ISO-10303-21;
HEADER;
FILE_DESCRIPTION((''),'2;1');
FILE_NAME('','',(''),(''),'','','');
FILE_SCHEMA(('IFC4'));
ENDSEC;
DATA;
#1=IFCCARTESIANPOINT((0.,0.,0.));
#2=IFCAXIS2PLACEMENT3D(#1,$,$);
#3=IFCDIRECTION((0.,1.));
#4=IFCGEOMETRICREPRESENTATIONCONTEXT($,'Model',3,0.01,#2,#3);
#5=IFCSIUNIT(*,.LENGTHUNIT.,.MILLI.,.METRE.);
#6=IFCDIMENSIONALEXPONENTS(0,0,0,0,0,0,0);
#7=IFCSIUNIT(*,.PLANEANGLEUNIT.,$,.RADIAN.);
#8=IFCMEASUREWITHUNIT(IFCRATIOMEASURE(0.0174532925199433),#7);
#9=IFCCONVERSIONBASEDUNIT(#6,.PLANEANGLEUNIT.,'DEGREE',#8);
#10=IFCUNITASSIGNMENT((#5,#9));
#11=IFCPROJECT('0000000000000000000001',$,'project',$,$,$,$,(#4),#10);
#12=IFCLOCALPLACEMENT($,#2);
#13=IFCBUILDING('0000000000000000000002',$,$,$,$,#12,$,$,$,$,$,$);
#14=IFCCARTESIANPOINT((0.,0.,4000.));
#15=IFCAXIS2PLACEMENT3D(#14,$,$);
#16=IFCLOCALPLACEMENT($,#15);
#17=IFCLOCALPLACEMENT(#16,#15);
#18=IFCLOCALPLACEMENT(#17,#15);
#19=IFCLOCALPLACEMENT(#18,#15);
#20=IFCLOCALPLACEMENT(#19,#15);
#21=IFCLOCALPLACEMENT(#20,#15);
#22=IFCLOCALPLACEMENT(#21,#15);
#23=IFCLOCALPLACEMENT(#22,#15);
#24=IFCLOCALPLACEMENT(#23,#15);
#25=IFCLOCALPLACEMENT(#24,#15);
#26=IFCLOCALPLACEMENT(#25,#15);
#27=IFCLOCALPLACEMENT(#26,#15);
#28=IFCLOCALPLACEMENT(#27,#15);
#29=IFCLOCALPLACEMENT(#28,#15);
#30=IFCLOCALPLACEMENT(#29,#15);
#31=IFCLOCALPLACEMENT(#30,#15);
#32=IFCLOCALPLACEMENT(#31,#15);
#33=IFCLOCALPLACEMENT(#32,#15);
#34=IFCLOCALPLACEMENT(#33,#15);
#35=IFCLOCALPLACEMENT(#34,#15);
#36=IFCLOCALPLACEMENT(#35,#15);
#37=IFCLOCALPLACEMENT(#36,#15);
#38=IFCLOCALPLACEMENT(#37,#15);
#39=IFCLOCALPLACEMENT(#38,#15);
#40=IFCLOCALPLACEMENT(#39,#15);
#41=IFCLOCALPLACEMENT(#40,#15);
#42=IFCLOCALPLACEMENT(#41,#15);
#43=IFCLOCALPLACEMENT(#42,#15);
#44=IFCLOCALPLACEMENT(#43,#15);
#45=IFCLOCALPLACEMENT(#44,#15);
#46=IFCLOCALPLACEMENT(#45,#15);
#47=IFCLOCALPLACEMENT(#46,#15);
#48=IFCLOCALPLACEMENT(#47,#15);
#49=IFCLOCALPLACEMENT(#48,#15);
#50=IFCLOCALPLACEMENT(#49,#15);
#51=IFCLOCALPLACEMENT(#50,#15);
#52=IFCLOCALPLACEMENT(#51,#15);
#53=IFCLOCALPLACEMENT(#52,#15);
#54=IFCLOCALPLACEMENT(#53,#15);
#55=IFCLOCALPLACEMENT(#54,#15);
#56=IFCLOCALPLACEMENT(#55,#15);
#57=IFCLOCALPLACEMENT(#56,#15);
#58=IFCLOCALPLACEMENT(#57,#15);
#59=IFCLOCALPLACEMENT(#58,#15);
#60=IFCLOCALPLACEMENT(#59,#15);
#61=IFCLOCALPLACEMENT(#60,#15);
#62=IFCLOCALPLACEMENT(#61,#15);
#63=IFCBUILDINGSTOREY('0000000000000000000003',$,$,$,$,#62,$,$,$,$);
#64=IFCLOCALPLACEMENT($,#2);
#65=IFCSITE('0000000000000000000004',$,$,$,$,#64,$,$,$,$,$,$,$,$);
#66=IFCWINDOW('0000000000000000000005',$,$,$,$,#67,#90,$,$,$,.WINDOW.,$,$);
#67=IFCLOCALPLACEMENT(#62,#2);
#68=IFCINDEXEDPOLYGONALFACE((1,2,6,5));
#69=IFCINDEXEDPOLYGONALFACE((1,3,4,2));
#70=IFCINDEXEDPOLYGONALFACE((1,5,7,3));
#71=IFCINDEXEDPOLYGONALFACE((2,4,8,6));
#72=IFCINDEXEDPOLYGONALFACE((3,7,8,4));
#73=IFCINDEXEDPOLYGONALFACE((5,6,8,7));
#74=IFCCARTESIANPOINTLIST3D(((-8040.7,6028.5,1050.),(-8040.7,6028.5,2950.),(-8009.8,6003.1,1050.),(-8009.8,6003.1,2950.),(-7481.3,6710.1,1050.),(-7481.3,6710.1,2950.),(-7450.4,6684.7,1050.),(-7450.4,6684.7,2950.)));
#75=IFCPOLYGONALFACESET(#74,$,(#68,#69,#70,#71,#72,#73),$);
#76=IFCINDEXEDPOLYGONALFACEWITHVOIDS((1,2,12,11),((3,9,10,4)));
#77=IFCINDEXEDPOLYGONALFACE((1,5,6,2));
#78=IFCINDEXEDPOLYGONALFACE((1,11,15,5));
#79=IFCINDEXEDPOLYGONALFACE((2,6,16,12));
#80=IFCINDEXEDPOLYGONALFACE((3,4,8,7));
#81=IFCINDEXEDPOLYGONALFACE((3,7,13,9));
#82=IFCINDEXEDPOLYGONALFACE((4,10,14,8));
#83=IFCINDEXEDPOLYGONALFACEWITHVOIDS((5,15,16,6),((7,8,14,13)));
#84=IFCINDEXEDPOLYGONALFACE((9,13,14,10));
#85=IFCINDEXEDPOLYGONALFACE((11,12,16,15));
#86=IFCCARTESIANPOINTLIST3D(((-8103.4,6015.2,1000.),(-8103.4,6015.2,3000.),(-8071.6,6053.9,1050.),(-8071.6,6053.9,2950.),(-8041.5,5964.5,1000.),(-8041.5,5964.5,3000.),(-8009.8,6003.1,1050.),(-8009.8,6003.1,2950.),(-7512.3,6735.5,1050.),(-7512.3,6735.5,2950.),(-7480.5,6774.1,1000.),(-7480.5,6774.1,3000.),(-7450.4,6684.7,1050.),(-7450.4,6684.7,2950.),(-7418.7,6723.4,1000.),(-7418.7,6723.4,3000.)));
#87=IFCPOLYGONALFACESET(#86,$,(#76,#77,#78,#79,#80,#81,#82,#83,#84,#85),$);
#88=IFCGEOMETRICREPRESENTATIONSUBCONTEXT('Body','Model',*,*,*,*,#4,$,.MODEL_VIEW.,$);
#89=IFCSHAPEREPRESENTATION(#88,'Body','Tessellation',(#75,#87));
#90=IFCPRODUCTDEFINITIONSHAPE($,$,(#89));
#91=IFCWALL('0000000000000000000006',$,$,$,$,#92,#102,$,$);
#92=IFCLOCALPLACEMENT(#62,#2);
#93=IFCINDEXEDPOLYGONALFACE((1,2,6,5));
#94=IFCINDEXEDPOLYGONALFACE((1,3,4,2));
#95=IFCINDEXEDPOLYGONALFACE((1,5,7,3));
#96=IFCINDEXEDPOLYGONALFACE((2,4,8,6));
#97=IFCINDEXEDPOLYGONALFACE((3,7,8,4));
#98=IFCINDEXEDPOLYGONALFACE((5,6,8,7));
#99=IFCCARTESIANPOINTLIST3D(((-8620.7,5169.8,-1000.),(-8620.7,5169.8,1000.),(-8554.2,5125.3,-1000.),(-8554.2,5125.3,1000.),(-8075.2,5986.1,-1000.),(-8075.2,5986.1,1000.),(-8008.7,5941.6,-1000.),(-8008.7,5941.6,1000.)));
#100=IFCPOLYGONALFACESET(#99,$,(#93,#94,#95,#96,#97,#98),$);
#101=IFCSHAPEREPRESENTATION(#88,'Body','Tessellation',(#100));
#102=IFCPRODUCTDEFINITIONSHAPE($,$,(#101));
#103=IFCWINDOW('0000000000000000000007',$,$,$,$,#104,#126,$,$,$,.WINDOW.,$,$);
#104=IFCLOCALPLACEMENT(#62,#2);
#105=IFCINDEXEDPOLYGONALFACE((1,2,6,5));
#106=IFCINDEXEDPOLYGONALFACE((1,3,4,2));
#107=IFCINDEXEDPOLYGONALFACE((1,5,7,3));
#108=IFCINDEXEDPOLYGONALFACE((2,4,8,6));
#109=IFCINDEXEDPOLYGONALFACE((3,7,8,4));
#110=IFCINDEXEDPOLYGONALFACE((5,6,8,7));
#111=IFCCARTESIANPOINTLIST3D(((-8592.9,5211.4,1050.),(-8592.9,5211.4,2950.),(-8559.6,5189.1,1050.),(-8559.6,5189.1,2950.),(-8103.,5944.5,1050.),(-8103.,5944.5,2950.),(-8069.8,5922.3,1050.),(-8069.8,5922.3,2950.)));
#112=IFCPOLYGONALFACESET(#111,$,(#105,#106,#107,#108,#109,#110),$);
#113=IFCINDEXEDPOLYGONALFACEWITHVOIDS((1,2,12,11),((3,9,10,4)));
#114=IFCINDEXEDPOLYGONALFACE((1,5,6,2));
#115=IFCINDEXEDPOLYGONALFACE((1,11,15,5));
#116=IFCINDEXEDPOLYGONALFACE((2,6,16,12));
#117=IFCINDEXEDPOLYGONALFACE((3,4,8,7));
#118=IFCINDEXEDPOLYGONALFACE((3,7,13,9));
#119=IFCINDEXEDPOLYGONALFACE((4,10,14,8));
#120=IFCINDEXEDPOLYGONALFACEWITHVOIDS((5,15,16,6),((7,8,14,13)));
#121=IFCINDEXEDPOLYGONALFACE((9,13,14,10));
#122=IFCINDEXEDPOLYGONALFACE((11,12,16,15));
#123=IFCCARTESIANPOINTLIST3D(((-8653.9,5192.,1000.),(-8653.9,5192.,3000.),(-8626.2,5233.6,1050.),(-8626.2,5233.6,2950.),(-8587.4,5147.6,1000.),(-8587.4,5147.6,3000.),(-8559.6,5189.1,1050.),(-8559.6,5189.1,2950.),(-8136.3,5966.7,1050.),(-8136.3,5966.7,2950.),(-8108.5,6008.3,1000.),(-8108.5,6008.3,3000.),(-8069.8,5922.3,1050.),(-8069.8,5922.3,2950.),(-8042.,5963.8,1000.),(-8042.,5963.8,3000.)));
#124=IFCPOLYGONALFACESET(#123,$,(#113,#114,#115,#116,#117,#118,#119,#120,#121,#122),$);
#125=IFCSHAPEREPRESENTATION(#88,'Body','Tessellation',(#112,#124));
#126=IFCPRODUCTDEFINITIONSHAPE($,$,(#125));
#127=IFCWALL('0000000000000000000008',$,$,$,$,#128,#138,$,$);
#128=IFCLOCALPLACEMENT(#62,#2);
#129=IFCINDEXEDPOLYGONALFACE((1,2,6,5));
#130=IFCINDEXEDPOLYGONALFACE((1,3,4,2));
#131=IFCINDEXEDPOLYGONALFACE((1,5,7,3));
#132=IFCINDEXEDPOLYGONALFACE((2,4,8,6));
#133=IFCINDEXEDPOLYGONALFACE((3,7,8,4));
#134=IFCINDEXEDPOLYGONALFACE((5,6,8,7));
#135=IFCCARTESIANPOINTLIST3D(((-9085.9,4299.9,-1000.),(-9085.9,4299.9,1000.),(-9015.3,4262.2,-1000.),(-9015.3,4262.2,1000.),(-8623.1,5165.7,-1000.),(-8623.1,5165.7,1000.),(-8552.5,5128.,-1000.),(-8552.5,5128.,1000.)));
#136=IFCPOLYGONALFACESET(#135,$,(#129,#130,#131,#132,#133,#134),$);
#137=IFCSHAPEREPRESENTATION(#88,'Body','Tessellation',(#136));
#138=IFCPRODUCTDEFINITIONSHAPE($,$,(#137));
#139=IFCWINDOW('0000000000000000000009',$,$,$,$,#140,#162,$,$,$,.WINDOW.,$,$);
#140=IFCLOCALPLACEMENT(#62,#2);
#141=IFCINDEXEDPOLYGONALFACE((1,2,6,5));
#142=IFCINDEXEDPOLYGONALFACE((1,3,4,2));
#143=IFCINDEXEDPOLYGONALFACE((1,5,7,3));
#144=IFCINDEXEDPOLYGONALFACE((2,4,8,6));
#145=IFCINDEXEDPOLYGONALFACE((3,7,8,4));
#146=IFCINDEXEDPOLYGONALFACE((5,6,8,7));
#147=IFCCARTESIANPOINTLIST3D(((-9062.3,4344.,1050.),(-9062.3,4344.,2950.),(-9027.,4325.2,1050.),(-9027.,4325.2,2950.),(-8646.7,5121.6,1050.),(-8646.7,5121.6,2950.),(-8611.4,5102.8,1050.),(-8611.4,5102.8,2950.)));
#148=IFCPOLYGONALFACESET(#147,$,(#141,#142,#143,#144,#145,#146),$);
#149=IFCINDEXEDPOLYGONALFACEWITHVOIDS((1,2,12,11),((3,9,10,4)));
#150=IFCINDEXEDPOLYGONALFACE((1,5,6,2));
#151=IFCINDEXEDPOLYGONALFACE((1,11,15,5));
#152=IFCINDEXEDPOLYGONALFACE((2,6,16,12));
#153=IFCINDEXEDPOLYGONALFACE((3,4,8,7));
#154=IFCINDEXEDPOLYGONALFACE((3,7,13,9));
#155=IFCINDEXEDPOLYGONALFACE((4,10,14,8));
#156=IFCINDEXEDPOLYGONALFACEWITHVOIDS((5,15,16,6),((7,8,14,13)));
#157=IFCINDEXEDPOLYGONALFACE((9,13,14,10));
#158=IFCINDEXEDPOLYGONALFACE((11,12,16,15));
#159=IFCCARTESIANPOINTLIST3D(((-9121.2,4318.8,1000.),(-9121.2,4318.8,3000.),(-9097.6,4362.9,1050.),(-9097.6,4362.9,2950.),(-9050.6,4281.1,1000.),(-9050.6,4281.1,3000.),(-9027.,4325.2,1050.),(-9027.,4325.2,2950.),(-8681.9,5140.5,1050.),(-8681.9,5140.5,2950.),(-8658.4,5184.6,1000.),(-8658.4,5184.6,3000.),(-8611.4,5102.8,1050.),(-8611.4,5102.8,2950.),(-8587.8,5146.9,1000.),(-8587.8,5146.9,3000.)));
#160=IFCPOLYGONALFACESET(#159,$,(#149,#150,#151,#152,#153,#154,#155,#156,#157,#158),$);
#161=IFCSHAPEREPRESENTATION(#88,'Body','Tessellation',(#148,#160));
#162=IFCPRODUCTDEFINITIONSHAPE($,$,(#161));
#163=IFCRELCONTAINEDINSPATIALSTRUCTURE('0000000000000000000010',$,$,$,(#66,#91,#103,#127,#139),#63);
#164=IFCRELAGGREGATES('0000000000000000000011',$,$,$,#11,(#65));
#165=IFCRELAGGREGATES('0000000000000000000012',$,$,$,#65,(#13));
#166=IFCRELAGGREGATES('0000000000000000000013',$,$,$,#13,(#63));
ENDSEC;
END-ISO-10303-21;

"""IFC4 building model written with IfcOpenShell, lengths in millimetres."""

from ifc_helpers import new_model, entity, si_unit, converted_unit, direction, frame, origin, origin_2d, place, context, subcontext, project, spatial, rectangle, extrude, element, save


model = new_model("IFC4")

# Units and contexts
model_context = context("Model", 3, precision=0.01, world=origin(), true_north=direction((0.0, 1.0)))
body_context = subcontext(model_context, "Body", "Model", "MODEL_VIEW")
ifc_project = project(units=[si_unit("LENGTHUNIT", "METRE", prefix="MILLI"), converted_unit("PLANEANGLEUNIT", "DEGREE", entity("IfcRatioMeasure", 0.0174532925199433), si_unit("PLANEANGLEUNIT", "RADIAN"), dimensions=[0, 0, 0, 0, 0, 0, 0])], contexts=[model_context])

# Site, building, storey
site_placement = place(None, origin())
site = spatial("IfcSite", under=ifc_project, at=site_placement)
building_placement = place(None, origin())
building = spatial("IfcBuilding", under=site, at=building_placement)
placement_1 = place(None, frame((0.0, 0.0, 4000.0)))
placement_2 = place(placement_1, frame((0.0, 0.0, 4000.0)))
placement_3 = place(placement_2, frame((0.0, 0.0, 4000.0)))
placement_4 = place(placement_3, frame((0.0, 0.0, 4000.0)))
placement_5 = place(placement_4, frame((0.0, 0.0, 4000.0)))
placement_6 = place(placement_5, frame((0.0, 0.0, 4000.0)))
placement_7 = place(placement_6, frame((0.0, 0.0, 4000.0)))
placement_8 = place(placement_7, frame((0.0, 0.0, 4000.0)))
placement_9 = place(placement_8, frame((0.0, 0.0, 4000.0)))
placement_10 = place(placement_9, frame((0.0, 0.0, 4000.0)))
placement_11 = place(placement_10, frame((0.0, 0.0, 4000.0)))
placement_12 = place(placement_11, frame((0.0, 0.0, 4000.0)))
placement_13 = place(placement_12, frame((0.0, 0.0, 4000.0)))
placement_14 = place(placement_13, frame((0.0, 0.0, 4000.0)))
placement_15 = place(placement_14, frame((0.0, 0.0, 4000.0)))
placement_16 = place(placement_15, frame((0.0, 0.0, 4000.0)))
placement_17 = place(placement_16, frame((0.0, 0.0, 4000.0)))
placement_18 = place(placement_17, frame((0.0, 0.0, 4000.0)))
placement_19 = place(placement_18, frame((0.0, 0.0, 4000.0)))
placement_20 = place(placement_19, frame((0.0, 0.0, 4000.0)))
placement_21 = place(placement_20, frame((0.0, 0.0, 4000.0)))
placement_22 = place(placement_21, frame((0.0, 0.0, 4000.0)))
placement_23 = place(placement_22, frame((0.0, 0.0, 4000.0)))
placement_24 = place(placement_23, frame((0.0, 0.0, 4000.0)))
placement_25 = place(placement_24, frame((0.0, 0.0, 4000.0)))
placement_26 = place(placement_25, frame((0.0, 0.0, 4000.0)))
placement_27 = place(placement_26, frame((0.0, 0.0, 4000.0)))
placement_28 = place(placement_27, frame((0.0, 0.0, 4000.0)))
placement_29 = place(placement_28, frame((0.0, 0.0, 4000.0)))
placement_30 = place(placement_29, frame((0.0, 0.0, 4000.0)))
placement_31 = place(placement_30, frame((0.0, 0.0, 4000.0)))
placement_32 = place(placement_31, frame((0.0, 0.0, 4000.0)))
placement_33 = place(placement_32, frame((0.0, 0.0, 4000.0)))
placement_34 = place(placement_33, frame((0.0, 0.0, 4000.0)))
placement_35 = place(placement_34, frame((0.0, 0.0, 4000.0)))
placement_36 = place(placement_35, frame((0.0, 0.0, 4000.0)))
placement_37 = place(placement_36, frame((0.0, 0.0, 4000.0)))
placement_38 = place(placement_37, frame((0.0, 0.0, 4000.0)))
placement_39 = place(placement_38, frame((0.0, 0.0, 4000.0)))
placement_40 = place(placement_39, frame((0.0, 0.0, 4000.0)))
placement_41 = place(placement_40, frame((0.0, 0.0, 4000.0)))
placement_42 = place(placement_41, frame((0.0, 0.0, 4000.0)))
placement_43 = place(placement_42, frame((0.0, 0.0, 4000.0)))
placement_44 = place(placement_43, frame((0.0, 0.0, 4000.0)))
placement_45 = place(placement_44, frame((0.0, 0.0, 4000.0)))
placement_46 = place(placement_45, frame((0.0, 0.0, 4000.0)))
storey_placement = place(placement_46, frame((0.0, 0.0, 4000.0)))
storey = spatial("IfcBuildingStorey", under=building, at=storey_placement)

# Shared definitions
cartesian_point_1 = entity("IfcCartesianPoint", [-440.9, -950.0])
shared_polyline = entity("IfcPolyline", [cartesian_point_1, entity("IfcCartesianPoint", [-440.9, 950.0]), entity("IfcCartesianPoint", [-440.9, 950.0]), entity("IfcCartesianPoint", [440.9, 950.0]), entity("IfcCartesianPoint", [440.9, 950.0]), entity("IfcCartesianPoint", [440.9, -950.0]), entity("IfcCartesianPoint", [440.9, -950.0]), entity("IfcCartesianPoint", [-440.9, -950.0]), cartesian_point_1])

# Window
window_1_placement = place(storey_placement, frame((-7730.1, 6343.9, 2000.0), z_axis=(0.0, 0.0, 1.0), x_axis=(-6343.932486, -7730.104825, 0.0)))
cartesian_point_2 = entity("IfcCartesianPoint", [-490.9, -1000.0])
element("IfcWindow", 1, at=window_1_placement, inside=storey, PredefinedType="WINDOW", context=body_context, shape_type="SweptSolid", body=[
    entity("IfcExtrudedAreaSolid", entity("IfcArbitraryClosedProfileDef", "AREA", None, shared_polyline), entity("IfcAxis2Placement3D", entity("IfcCartesianPoint", [0.0, 0.0, 0.0]), entity("IfcDirection", [0.0, -1.0, 0.0]), entity("IfcDirection", [1.0, 0.0, 0.0])), entity("IfcDirection", [0.0, 0.0, 1.0]), 40.0),
    entity("IfcExtrudedAreaSolid", entity("IfcArbitraryProfileDefWithVoids", "AREA", None, entity("IfcPolyline", [cartesian_point_2, entity("IfcCartesianPoint", [-490.9, 1000.0]), entity("IfcCartesianPoint", [-490.9, 1000.0]), entity("IfcCartesianPoint", [490.9, 1000.0]), entity("IfcCartesianPoint", [490.9, 1000.0]), entity("IfcCartesianPoint", [490.9, -1000.0]), entity("IfcCartesianPoint", [490.9, -1000.0]), entity("IfcCartesianPoint", [-490.9, -1000.0]), cartesian_point_2]), [shared_polyline]), entity("IfcAxis2Placement3D", entity("IfcCartesianPoint", [0.0, 0.0, 0.0]), entity("IfcDirection", [0.0, -1.0, 0.0]), entity("IfcDirection", [1.0, 0.0, 0.0])), entity("IfcDirection", [0.0, 0.0, 1.0]), 80.0),
])

# Wall
wall_1_placement = place(storey_placement, frame((-8314.7, 5555.7, -1000.0), z_axis=(0.0, 0.0, 1.0), x_axis=(-5555.701616, -8314.6966, 0.0)))
element("IfcWall", 2, at=wall_1_placement, inside=storey, context=body_context, shape_type="SweptSolid", body=[
    extrude(rectangle(XDim=981.7, YDim=80.0, at=origin_2d()), origin(), (0.0, 0.0, 1.0), 2000.0),
])

# Window
window_2_placement = place(storey_placement, frame((-8314.7, 5555.7, 2000.0), z_axis=(0.0, 0.0, 1.0), x_axis=(-5555.701616, -8314.6966, 0.0)))
cartesian_point_3 = entity("IfcCartesianPoint", [-490.9, -1000.0])
element("IfcWindow", 3, at=window_2_placement, inside=storey, PredefinedType="WINDOW", context=body_context, shape_type="SweptSolid", body=[
    entity("IfcExtrudedAreaSolid", entity("IfcArbitraryClosedProfileDef", "AREA", None, shared_polyline), entity("IfcAxis2Placement3D", entity("IfcCartesianPoint", [0.0, 0.0, 0.0]), entity("IfcDirection", [0.0, -1.0, 0.0]), entity("IfcDirection", [1.0, 0.0, 0.0])), entity("IfcDirection", [0.0, 0.0, 1.0]), 40.0),
    entity("IfcExtrudedAreaSolid", entity("IfcArbitraryProfileDefWithVoids", "AREA", None, entity("IfcPolyline", [cartesian_point_3, entity("IfcCartesianPoint", [-490.9, 1000.0]), entity("IfcCartesianPoint", [-490.9, 1000.0]), entity("IfcCartesianPoint", [490.9, 1000.0]), entity("IfcCartesianPoint", [490.9, 1000.0]), entity("IfcCartesianPoint", [490.9, -1000.0]), entity("IfcCartesianPoint", [490.9, -1000.0]), entity("IfcCartesianPoint", [-490.9, -1000.0]), cartesian_point_3]), [shared_polyline]), entity("IfcAxis2Placement3D", entity("IfcCartesianPoint", [0.0, 0.0, 0.0]), entity("IfcDirection", [0.0, -1.0, 0.0]), entity("IfcDirection", [1.0, 0.0, 0.0])), entity("IfcDirection", [0.0, 0.0, 1.0]), 80.0),
])

# Wall
wall_2_placement = place(storey_placement, frame((-8819.2, 4714.0, -1000.0), z_axis=(0.0, 0.0, 1.0), x_axis=(-4713.96836, -8819.212113, 0.0)))
element("IfcWall", 4, at=wall_2_placement, inside=storey, context=body_context, shape_type="SweptSolid", body=[
    extrude(rectangle(XDim=981.7, YDim=80.0, at=origin_2d()), origin(), (0.0, 0.0, 1.0), 2000.0),
])

# Window
window_3_placement = place(storey_placement, frame((-8819.2, 4714.0, 2000.0), z_axis=(0.0, 0.0, 1.0), x_axis=(-4713.96836, -8819.212113, 0.0)))
cartesian_point_4 = entity("IfcCartesianPoint", [-490.9, -1000.0])
element("IfcWindow", 5, at=window_3_placement, inside=storey, PredefinedType="WINDOW", context=body_context, shape_type="SweptSolid", body=[
    entity("IfcExtrudedAreaSolid", entity("IfcArbitraryClosedProfileDef", "AREA", None, shared_polyline), entity("IfcAxis2Placement3D", entity("IfcCartesianPoint", [0.0, 0.0, 0.0]), entity("IfcDirection", [0.0, -1.0, 0.0]), entity("IfcDirection", [1.0, 0.0, 0.0])), entity("IfcDirection", [0.0, 0.0, 1.0]), 40.0),
    entity("IfcExtrudedAreaSolid", entity("IfcArbitraryProfileDefWithVoids", "AREA", None, entity("IfcPolyline", [cartesian_point_4, entity("IfcCartesianPoint", [-490.9, 1000.0]), entity("IfcCartesianPoint", [-490.9, 1000.0]), entity("IfcCartesianPoint", [490.9, 1000.0]), entity("IfcCartesianPoint", [490.9, 1000.0]), entity("IfcCartesianPoint", [490.9, -1000.0]), entity("IfcCartesianPoint", [490.9, -1000.0]), entity("IfcCartesianPoint", [-490.9, -1000.0]), cartesian_point_4]), [shared_polyline]), entity("IfcAxis2Placement3D", entity("IfcCartesianPoint", [0.0, 0.0, 0.0]), entity("IfcDirection", [0.0, -1.0, 0.0]), entity("IfcDirection", [1.0, 0.0, 0.0])), entity("IfcDirection", [0.0, 0.0, 1.0]), 80.0),
])

save(model, "model.ifc")
